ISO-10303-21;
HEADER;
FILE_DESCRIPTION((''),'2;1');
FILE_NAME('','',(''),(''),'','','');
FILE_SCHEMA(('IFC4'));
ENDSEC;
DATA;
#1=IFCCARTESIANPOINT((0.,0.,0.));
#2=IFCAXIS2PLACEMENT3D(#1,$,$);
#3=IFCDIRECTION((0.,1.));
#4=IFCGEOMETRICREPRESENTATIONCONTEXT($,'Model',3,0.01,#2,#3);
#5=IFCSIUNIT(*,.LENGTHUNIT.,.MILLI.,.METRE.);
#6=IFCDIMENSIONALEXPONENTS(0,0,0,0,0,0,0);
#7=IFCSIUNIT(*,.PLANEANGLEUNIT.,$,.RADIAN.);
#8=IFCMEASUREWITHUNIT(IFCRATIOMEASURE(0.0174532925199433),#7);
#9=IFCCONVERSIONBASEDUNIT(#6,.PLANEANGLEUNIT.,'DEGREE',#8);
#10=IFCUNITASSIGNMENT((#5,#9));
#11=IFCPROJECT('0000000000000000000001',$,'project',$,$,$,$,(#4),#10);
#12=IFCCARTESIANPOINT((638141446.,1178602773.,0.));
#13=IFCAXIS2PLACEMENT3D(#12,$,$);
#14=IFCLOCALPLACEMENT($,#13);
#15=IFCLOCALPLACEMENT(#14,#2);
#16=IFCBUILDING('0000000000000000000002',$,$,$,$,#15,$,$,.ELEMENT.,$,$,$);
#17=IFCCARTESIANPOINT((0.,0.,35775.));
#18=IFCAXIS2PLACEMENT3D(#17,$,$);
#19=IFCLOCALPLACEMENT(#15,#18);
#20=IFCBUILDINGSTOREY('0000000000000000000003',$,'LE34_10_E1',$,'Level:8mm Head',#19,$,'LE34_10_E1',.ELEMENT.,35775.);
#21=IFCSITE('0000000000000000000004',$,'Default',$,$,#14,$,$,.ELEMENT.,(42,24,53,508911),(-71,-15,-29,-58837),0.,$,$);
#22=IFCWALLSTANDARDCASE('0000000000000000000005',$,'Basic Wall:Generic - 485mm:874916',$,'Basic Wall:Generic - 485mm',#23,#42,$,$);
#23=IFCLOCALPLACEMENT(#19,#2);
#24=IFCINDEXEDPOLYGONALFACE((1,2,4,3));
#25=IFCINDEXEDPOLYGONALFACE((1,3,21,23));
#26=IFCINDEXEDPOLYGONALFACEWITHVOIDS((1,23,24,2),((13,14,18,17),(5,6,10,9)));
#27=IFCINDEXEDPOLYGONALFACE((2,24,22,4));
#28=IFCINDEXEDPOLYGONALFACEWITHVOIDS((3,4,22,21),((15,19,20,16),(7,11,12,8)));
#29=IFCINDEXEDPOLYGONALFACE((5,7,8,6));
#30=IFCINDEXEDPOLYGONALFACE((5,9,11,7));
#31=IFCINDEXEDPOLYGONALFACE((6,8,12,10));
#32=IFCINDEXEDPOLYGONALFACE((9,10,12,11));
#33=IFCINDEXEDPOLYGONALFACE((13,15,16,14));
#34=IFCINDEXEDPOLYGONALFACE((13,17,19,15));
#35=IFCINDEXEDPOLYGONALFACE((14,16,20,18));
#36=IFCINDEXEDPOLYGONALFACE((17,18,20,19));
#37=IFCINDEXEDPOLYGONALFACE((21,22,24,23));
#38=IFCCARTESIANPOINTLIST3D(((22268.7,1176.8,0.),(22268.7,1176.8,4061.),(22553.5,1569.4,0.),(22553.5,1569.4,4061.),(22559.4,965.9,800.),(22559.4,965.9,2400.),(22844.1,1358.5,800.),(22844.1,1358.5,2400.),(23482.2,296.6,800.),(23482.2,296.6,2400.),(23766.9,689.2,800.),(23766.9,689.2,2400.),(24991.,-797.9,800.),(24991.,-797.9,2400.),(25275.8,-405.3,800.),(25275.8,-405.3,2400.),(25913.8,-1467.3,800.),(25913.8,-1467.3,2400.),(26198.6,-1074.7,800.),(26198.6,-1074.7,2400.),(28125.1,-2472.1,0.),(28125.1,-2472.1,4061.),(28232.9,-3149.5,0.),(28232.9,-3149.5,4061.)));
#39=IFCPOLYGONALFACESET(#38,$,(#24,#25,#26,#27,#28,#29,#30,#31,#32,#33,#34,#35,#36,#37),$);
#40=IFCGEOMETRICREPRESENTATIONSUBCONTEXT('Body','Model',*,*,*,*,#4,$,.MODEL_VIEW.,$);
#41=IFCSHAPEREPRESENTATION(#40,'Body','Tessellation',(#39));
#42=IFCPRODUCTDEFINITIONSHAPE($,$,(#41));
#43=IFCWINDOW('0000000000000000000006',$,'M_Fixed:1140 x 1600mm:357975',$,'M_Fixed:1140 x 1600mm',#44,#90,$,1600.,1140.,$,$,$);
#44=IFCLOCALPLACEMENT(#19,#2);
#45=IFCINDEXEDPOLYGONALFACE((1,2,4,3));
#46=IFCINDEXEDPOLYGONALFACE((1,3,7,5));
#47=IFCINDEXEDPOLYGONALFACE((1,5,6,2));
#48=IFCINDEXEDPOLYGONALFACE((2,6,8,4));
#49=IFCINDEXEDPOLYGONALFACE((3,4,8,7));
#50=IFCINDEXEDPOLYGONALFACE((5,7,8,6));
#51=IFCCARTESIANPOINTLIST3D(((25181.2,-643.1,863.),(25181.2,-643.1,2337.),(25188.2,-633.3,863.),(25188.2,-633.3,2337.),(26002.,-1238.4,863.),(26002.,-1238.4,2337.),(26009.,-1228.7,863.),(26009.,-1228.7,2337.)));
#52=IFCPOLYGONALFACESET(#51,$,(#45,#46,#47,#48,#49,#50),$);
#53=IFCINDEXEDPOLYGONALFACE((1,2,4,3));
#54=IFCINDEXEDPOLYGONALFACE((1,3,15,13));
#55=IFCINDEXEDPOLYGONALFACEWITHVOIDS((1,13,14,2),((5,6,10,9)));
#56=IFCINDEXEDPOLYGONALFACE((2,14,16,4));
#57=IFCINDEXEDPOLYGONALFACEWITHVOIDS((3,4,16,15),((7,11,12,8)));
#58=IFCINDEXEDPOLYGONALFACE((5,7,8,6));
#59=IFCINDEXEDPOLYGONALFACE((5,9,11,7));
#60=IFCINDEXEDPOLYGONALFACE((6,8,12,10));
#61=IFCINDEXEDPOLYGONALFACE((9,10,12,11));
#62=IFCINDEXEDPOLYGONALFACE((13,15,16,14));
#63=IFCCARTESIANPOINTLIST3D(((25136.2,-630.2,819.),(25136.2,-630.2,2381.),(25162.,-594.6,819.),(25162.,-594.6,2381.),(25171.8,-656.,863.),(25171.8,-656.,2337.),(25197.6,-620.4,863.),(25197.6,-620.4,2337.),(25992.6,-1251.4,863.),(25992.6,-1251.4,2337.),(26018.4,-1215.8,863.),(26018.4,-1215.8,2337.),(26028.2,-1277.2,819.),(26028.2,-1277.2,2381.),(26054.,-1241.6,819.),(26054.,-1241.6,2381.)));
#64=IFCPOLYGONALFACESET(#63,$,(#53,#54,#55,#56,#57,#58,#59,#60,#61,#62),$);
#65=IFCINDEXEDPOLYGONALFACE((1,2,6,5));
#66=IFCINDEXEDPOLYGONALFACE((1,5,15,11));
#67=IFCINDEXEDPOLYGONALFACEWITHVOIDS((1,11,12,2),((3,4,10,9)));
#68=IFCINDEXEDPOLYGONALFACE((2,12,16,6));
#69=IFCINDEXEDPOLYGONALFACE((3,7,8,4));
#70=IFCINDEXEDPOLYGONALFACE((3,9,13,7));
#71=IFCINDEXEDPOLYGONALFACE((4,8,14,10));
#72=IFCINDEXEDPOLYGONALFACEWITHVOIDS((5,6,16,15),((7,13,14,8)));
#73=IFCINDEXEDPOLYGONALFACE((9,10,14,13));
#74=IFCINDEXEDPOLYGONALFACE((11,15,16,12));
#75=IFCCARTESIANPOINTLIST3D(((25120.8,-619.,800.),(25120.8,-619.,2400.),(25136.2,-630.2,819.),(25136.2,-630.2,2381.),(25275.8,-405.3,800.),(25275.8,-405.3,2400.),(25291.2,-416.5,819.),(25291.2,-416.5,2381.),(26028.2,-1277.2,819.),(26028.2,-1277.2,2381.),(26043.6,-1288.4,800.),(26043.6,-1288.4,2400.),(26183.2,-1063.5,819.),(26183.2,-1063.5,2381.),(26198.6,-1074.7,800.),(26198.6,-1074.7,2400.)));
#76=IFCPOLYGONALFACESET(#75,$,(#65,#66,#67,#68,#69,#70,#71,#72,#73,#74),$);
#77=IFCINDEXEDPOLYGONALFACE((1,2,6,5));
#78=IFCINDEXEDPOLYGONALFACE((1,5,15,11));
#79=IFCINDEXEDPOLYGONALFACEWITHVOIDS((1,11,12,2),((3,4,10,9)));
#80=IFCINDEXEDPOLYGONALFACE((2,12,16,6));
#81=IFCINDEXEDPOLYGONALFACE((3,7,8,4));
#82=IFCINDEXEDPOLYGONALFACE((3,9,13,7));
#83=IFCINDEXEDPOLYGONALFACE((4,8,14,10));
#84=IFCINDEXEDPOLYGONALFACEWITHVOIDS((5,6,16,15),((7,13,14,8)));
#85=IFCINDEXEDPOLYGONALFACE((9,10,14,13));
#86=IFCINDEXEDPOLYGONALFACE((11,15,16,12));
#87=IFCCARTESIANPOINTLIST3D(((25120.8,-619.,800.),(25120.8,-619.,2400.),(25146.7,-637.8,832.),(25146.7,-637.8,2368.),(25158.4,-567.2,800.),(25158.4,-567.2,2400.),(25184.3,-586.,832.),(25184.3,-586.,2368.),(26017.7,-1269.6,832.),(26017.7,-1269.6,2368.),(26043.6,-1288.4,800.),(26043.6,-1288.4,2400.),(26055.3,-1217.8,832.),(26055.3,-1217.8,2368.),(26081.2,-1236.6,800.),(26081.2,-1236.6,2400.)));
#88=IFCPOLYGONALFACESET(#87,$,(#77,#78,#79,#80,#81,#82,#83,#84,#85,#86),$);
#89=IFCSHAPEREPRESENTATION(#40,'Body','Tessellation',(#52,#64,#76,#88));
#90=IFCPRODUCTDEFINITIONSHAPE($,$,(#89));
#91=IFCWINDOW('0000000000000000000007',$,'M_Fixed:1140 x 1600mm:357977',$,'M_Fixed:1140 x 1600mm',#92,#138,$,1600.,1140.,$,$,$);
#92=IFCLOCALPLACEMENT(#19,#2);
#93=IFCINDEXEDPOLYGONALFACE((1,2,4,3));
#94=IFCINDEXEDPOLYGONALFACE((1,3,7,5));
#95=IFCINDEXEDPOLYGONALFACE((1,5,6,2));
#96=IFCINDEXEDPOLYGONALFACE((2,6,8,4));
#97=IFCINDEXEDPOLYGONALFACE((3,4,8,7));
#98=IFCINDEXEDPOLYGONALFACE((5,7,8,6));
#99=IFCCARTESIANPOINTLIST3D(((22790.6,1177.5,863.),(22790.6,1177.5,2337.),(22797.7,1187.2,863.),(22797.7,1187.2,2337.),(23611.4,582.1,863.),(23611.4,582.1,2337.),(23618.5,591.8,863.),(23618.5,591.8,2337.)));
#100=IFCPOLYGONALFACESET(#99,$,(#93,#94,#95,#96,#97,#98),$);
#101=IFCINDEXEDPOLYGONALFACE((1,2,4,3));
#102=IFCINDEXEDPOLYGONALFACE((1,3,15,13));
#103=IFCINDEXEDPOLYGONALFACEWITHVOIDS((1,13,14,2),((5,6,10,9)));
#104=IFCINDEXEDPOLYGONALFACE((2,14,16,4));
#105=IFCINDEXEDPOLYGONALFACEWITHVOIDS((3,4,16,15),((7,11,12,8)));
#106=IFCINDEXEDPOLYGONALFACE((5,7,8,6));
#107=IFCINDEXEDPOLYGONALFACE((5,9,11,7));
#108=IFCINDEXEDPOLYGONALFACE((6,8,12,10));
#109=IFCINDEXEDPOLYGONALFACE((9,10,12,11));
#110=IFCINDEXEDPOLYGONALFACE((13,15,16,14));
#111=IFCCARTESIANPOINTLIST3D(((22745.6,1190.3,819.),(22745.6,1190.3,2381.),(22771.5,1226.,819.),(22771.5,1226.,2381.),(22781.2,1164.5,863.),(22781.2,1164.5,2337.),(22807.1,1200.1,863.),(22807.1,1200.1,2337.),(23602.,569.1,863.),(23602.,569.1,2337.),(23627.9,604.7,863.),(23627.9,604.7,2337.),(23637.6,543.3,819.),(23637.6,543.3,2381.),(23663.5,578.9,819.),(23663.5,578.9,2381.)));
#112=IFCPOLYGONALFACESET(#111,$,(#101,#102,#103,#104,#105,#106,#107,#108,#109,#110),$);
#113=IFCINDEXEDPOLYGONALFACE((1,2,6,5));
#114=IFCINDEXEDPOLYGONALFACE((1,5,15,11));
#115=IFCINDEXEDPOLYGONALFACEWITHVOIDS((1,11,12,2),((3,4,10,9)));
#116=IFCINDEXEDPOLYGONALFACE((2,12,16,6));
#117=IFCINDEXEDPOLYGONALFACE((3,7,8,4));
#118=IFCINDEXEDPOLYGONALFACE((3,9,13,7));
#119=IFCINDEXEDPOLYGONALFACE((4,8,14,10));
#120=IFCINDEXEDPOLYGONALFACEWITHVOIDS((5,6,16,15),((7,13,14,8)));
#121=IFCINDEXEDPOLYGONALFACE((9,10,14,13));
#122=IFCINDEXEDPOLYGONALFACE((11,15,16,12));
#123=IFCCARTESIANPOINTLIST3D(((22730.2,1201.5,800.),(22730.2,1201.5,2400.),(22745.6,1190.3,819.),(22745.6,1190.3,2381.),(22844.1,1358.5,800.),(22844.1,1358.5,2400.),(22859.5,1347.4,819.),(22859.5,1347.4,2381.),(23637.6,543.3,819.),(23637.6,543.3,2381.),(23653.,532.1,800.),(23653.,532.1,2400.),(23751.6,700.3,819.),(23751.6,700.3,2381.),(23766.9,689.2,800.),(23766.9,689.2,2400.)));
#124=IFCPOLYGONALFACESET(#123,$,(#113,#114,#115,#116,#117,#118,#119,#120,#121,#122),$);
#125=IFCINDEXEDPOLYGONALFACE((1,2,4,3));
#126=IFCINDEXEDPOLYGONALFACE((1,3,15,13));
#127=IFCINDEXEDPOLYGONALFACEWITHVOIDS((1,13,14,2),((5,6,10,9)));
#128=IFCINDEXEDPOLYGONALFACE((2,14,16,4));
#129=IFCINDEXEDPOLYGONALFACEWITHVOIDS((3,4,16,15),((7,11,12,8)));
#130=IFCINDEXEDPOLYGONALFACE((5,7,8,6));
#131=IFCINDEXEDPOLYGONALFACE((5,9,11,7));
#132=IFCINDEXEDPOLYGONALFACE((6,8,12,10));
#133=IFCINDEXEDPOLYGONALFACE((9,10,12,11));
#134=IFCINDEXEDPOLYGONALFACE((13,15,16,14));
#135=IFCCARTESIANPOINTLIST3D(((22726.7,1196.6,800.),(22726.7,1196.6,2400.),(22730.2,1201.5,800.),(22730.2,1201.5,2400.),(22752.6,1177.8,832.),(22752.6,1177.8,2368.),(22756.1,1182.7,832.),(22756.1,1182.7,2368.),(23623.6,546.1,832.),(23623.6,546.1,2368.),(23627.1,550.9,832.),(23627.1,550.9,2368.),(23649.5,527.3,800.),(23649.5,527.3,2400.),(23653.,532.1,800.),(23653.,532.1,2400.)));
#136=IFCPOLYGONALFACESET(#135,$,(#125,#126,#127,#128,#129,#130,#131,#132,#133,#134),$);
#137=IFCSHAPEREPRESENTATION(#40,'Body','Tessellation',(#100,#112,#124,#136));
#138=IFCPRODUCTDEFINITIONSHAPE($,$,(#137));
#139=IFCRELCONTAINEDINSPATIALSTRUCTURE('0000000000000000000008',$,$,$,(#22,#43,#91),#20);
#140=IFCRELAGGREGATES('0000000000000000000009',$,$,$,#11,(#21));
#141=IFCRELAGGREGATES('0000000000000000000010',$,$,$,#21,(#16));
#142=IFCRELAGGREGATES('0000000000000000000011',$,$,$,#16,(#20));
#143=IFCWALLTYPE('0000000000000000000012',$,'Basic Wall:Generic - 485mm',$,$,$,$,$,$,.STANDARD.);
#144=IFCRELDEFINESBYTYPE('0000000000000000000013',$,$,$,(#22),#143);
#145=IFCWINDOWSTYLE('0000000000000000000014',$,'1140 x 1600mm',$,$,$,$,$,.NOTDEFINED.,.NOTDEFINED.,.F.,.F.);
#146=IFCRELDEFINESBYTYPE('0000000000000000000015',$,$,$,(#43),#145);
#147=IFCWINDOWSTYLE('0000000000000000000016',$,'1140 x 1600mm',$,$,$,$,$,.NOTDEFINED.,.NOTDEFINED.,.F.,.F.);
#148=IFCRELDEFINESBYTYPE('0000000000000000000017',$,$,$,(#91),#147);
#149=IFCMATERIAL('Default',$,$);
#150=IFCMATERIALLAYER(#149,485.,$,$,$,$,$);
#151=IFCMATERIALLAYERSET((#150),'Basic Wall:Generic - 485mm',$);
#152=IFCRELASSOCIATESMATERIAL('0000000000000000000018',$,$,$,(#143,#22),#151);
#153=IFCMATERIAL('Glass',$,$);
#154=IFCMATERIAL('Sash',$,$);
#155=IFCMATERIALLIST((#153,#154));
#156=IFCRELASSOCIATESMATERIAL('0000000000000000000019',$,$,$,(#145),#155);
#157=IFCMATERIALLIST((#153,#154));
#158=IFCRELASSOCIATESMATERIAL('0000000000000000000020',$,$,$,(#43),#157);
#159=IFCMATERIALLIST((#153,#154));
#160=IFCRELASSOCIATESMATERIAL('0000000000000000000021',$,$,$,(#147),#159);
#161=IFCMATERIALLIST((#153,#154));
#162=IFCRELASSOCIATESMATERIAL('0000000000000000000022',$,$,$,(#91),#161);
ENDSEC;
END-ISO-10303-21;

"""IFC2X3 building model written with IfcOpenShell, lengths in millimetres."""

from ifc_helpers import new_model, entity, si_unit, converted_unit, direction, frame, frame_2d, origin, origin_2d_with_axis, place, context, subcontext, project, spatial, polyline, rectangle, outline, extrude, source, transform, mapped, material, material_list, layer, layer_set, layer_usage, type_object, type_shapes, element, fill, save


model = new_model("IFC2X3")

# Units and contexts
model_context = context("Model", 3, precision=0.01, world=origin(), true_north=direction((0.0, 1.0)))
body_context = subcontext(model_context, "Body", "Model", "MODEL_VIEW")
ifc_project = project(units=[si_unit("LENGTHUNIT", "METRE", prefix="MILLI"), converted_unit("PLANEANGLEUNIT", "DEGREE", entity("IfcRatioMeasure", 0.0174532925199433), si_unit("PLANEANGLEUNIT", "RADIAN"), dimensions=[0, 0, 0, 0, 0, 0, 0])], contexts=[model_context])

# Site, building, storey
site_placement = place(None, frame((638141446.0, 1178602773.0, 0.0)))
site = spatial("IfcSite", under=ifc_project, at=site_placement, Name="Default", CompositionType="ELEMENT", RefLatitude=(42, 24, 53, 508911), RefLongitude=(-71, -15, -29, -58837), RefElevation=0.0)
building_placement = place(site_placement, origin())
building = spatial("IfcBuilding", under=site, at=building_placement, CompositionType="ELEMENT")
storey_placement = place(building_placement, frame((0.0, 0.0, 35775.0)))
storey = spatial("IfcBuildingStorey", under=building, at=storey_placement, Name="LE34_10_E1", ObjectType="Level:8mm Head", LongName="LE34_10_E1", CompositionType="ELEMENT", Elevation=35775.0)

# Shared definitions
ifc_material_1 = material(Name="Default")

# Wall, openings, windows
ifc_layer_1 = layer(ifc_material_1, 485.0)
ifc_layer_set_1 = layer_set([ifc_layer_1], Name="Basic Wall:Generic - 485mm")
ifc_layer_usage_1 = layer_usage(ifc_layer_set_1, "AXIS2", "NEGATIVE", 242.5)
wall_type_1 = type_object("IfcWallType", Name="Basic Wall:Generic - 485mm", PredefinedType="STANDARD", material=ifc_layer_set_1)
wall_1_placement = place(storey_placement, frame((22411.1, 1373.1, 0.0), z_axis=(0.0, 0.0, 1.0), x_axis=(0.809468, -0.587164, 0.0)))
wall_1 = element("IfcWallStandardCase", 1, at=wall_1_placement, inside=storey, type_object=wall_type_1, material=ifc_layer_usage_1, Name="Basic Wall:Generic - 485mm:874916", ObjectType="Basic Wall:Generic - 485mm", context=body_context, shape_type="SweptSolid", body=[
    extrude(outline(polyline([(7368.1, -242.5), (6883.1, 242.5), (3248.2, 242.5), (2978.2, 242.5), (0.0, 242.5), (0.0, 237.5), (0.0, 42.5), (0.0, -242.5), (1837.4, -242.5), (2967.4, -242.5), (3357.5, -242.5), (4487.7, -242.5), (7368.1, -242.5)])), origin(), (0.0, 0.0, 1.0), 4061.0),
])
opening_1_placement = place(wall_1_placement, frame((3363.1, -242.5, 800.0)))
opening_1 = element("IfcOpeningElement", 2, at=opening_1_placement, cuts=wall_1, ObjectType="Opening", context=body_context, shape_type="SweptSolid", body=[
    extrude(rectangle(XDim=1600.0, YDim=1140.0, at=frame_2d((800.0, 570.0), x_axis=(1.0, 0.0))), frame((0.0, 0.0, 0.0), z_axis=(0.0, 1.0, 0.0), x_axis=(0.0, 0.0, 1.0)), (0.0, 0.0, 1.0), 485.0),
])
opening_2_placement = place(wall_1_placement, frame((359.1, -242.5, 800.0)))
opening_2 = element("IfcOpeningElement", 3, at=opening_2_placement, cuts=wall_1, ObjectType="Opening", context=body_context, shape_type="SweptSolid", body=[
    extrude(rectangle(XDim=1600.0, YDim=1140.0, at=frame_2d((800.0, 570.0), x_axis=(1.0, 0.0))), frame((0.0, 0.0, 0.0), z_axis=(0.0, 1.0, 0.0), x_axis=(0.0, 0.0, 1.0)), (0.0, 0.0, 1.0), 485.0),
])
ifc_material_2 = material(Name="Glass")
ifc_material_3 = material(Name="Sash")
ifc_material_list_1 = material_list([ifc_material_2, ifc_material_3])
ifc_material_list_2 = material_list([ifc_material_2, ifc_material_3])
window_style_1 = type_object("IfcWindowStyle", Name="1140 x 1600mm", ConstructionType="NOTDEFINED", OperationType="NOTDEFINED", ParameterTakesPrecedence=False, Sizeable=False, material=ifc_material_list_2)
shared_shape_1 = source(origin(), body_context, "Body", "SweptSolid", [
    extrude(rectangle(XDim=12.0, YDim=1014.0, at=origin_2d_with_axis()), frame((570.0, 243.0, 63.0), z_axis=(0.0, 0.0, 1.0), x_axis=(0.0, -1.0, 0.0)), (0.0, 0.0, 1.0), 1474.0),
    extrude(outline(polyline([(-551.0, -781.0), (551.0, -781.0), (551.0, 781.0), (-551.0, 781.0), (-551.0, -781.0)]), holes=[polyline([(-507.0, -737.0), (-507.0, 737.0), (507.0, 737.0), (507.0, -737.0), (-507.0, -737.0)])]), frame((570.0, 221.0, 800.0), z_axis=(0.0, 1.0, 0.0), x_axis=(1.0, 0.0, 0.0)), (0.0, 0.0, 1.0), 44.0),
    extrude(outline(polyline([(-570.0, -800.0), (570.0, -800.0), (570.0, 800.0), (-570.0, 800.0), (-570.0, -800.0)]), holes=[polyline([(-551.0, -781.0), (-551.0, 781.0), (551.0, 781.0), (551.0, -781.0), (-551.0, -781.0)])]), frame((570.0, 221.0, 800.0), z_axis=(0.0, 1.0, 0.0), x_axis=(1.0, 0.0, 0.0)), (0.0, 0.0, 1.0), 264.0),
    extrude(outline(polyline([(-570.0, -800.0), (570.0, -800.0), (570.0, 800.0), (-570.0, 800.0), (-570.0, -800.0)]), holes=[polyline([(-538.0, -768.0), (-538.0, 768.0), (538.0, 768.0), (538.0, -768.0), (-538.0, -768.0)])]), frame((570.0, 221.0, 800.0), z_axis=(0.0, 1.0, 0.0), x_axis=(1.0, 0.0, 0.0)), (0.0, 0.0, 1.0), 64.0),
])
type_shapes(window_style_1, [shared_shape_1])
window_1_placement = place(opening_1_placement, origin())
window_1 = element("IfcWindow", 4, at=window_1_placement, inside=storey, type_object=window_style_1, material=ifc_material_list_1, Name="M_Fixed:1140 x 1600mm:357975", ObjectType="M_Fixed:1140 x 1600mm", OverallHeight=1600.0, OverallWidth=1140.0, context=body_context, shape_type="MappedRepresentation", body=[
    mapped(shared_shape_1, transform((0.0, 0.0, 0.0), scale=1.0)),
])
fill(opening_1, window_1)
ifc_material_list_3 = material_list([ifc_material_2, ifc_material_3])
ifc_material_list_4 = material_list([ifc_material_2, ifc_material_3])
window_style_2 = type_object("IfcWindowStyle", Name="1140 x 1600mm", ConstructionType="NOTDEFINED", OperationType="NOTDEFINED", ParameterTakesPrecedence=False, Sizeable=False, material=ifc_material_list_4)
shared_shape_2 = source(origin(), body_context, "Body", "SweptSolid", [
    extrude(rectangle(XDim=12.0, YDim=1014.0, at=frame_2d((0.0, 0.0), x_axis=(1.0, 0.0))), frame((570.0, 313.0, 63.0), z_axis=(0.0, 0.0, 1.0), x_axis=(0.0, -1.0, 0.0)), (0.0, 0.0, 1.0), 1474.0),
    extrude(outline(polyline([(-551.0, -781.0), (551.0, -781.0), (551.0, 781.0), (-551.0, 781.0), (-551.0, -781.0)]), holes=[polyline([(-507.0, -737.0), (-507.0, 737.0), (507.0, 737.0), (507.0, -737.0), (-507.0, -737.0)])]), frame((570.0, 291.0, 800.0), z_axis=(0.0, 1.0, 0.0), x_axis=(1.0, 0.0, 0.0)), (0.0, 0.0, 1.0), 44.0),
    extrude(outline(polyline([(-570.0, -800.0), (570.0, -800.0), (570.0, 800.0), (-570.0, 800.0), (-570.0, -800.0)]), holes=[polyline([(-551.0, -781.0), (-551.0, 781.0), (551.0, 781.0), (551.0, -781.0), (-551.0, -781.0)])]), frame((570.0, 291.0, 800.0), z_axis=(0.0, 1.0, 0.0), x_axis=(1.0, 0.0, 0.0)), (0.0, 0.0, 1.0), 194.0),
    extrude(outline(polyline([(-570.0, -800.0), (570.0, -800.0), (570.0, 800.0), (-570.0, 800.0), (-570.0, -800.0)]), holes=[polyline([(-538.0, -768.0), (-538.0, 768.0), (538.0, 768.0), (538.0, -768.0), (-538.0, -768.0)])]), frame((570.0, 285.0, 800.0), z_axis=(0.0, 1.0, 0.0), x_axis=(1.0, 0.0, 0.0)), (0.0, 0.0, 1.0), 6.0),
])
type_shapes(window_style_2, [shared_shape_2])
window_2_placement = place(opening_2_placement, origin())
window_2 = element("IfcWindow", 5, at=window_2_placement, inside=storey, type_object=window_style_2, material=ifc_material_list_3, Name="M_Fixed:1140 x 1600mm:357977", ObjectType="M_Fixed:1140 x 1600mm", OverallHeight=1600.0, OverallWidth=1140.0, context=body_context, shape_type="MappedRepresentation", body=[
    mapped(shared_shape_2, transform((0.0, 0.0, 0.0), scale=1.0)),
])
fill(opening_2, window_2)

save(model, "model.ifc")
